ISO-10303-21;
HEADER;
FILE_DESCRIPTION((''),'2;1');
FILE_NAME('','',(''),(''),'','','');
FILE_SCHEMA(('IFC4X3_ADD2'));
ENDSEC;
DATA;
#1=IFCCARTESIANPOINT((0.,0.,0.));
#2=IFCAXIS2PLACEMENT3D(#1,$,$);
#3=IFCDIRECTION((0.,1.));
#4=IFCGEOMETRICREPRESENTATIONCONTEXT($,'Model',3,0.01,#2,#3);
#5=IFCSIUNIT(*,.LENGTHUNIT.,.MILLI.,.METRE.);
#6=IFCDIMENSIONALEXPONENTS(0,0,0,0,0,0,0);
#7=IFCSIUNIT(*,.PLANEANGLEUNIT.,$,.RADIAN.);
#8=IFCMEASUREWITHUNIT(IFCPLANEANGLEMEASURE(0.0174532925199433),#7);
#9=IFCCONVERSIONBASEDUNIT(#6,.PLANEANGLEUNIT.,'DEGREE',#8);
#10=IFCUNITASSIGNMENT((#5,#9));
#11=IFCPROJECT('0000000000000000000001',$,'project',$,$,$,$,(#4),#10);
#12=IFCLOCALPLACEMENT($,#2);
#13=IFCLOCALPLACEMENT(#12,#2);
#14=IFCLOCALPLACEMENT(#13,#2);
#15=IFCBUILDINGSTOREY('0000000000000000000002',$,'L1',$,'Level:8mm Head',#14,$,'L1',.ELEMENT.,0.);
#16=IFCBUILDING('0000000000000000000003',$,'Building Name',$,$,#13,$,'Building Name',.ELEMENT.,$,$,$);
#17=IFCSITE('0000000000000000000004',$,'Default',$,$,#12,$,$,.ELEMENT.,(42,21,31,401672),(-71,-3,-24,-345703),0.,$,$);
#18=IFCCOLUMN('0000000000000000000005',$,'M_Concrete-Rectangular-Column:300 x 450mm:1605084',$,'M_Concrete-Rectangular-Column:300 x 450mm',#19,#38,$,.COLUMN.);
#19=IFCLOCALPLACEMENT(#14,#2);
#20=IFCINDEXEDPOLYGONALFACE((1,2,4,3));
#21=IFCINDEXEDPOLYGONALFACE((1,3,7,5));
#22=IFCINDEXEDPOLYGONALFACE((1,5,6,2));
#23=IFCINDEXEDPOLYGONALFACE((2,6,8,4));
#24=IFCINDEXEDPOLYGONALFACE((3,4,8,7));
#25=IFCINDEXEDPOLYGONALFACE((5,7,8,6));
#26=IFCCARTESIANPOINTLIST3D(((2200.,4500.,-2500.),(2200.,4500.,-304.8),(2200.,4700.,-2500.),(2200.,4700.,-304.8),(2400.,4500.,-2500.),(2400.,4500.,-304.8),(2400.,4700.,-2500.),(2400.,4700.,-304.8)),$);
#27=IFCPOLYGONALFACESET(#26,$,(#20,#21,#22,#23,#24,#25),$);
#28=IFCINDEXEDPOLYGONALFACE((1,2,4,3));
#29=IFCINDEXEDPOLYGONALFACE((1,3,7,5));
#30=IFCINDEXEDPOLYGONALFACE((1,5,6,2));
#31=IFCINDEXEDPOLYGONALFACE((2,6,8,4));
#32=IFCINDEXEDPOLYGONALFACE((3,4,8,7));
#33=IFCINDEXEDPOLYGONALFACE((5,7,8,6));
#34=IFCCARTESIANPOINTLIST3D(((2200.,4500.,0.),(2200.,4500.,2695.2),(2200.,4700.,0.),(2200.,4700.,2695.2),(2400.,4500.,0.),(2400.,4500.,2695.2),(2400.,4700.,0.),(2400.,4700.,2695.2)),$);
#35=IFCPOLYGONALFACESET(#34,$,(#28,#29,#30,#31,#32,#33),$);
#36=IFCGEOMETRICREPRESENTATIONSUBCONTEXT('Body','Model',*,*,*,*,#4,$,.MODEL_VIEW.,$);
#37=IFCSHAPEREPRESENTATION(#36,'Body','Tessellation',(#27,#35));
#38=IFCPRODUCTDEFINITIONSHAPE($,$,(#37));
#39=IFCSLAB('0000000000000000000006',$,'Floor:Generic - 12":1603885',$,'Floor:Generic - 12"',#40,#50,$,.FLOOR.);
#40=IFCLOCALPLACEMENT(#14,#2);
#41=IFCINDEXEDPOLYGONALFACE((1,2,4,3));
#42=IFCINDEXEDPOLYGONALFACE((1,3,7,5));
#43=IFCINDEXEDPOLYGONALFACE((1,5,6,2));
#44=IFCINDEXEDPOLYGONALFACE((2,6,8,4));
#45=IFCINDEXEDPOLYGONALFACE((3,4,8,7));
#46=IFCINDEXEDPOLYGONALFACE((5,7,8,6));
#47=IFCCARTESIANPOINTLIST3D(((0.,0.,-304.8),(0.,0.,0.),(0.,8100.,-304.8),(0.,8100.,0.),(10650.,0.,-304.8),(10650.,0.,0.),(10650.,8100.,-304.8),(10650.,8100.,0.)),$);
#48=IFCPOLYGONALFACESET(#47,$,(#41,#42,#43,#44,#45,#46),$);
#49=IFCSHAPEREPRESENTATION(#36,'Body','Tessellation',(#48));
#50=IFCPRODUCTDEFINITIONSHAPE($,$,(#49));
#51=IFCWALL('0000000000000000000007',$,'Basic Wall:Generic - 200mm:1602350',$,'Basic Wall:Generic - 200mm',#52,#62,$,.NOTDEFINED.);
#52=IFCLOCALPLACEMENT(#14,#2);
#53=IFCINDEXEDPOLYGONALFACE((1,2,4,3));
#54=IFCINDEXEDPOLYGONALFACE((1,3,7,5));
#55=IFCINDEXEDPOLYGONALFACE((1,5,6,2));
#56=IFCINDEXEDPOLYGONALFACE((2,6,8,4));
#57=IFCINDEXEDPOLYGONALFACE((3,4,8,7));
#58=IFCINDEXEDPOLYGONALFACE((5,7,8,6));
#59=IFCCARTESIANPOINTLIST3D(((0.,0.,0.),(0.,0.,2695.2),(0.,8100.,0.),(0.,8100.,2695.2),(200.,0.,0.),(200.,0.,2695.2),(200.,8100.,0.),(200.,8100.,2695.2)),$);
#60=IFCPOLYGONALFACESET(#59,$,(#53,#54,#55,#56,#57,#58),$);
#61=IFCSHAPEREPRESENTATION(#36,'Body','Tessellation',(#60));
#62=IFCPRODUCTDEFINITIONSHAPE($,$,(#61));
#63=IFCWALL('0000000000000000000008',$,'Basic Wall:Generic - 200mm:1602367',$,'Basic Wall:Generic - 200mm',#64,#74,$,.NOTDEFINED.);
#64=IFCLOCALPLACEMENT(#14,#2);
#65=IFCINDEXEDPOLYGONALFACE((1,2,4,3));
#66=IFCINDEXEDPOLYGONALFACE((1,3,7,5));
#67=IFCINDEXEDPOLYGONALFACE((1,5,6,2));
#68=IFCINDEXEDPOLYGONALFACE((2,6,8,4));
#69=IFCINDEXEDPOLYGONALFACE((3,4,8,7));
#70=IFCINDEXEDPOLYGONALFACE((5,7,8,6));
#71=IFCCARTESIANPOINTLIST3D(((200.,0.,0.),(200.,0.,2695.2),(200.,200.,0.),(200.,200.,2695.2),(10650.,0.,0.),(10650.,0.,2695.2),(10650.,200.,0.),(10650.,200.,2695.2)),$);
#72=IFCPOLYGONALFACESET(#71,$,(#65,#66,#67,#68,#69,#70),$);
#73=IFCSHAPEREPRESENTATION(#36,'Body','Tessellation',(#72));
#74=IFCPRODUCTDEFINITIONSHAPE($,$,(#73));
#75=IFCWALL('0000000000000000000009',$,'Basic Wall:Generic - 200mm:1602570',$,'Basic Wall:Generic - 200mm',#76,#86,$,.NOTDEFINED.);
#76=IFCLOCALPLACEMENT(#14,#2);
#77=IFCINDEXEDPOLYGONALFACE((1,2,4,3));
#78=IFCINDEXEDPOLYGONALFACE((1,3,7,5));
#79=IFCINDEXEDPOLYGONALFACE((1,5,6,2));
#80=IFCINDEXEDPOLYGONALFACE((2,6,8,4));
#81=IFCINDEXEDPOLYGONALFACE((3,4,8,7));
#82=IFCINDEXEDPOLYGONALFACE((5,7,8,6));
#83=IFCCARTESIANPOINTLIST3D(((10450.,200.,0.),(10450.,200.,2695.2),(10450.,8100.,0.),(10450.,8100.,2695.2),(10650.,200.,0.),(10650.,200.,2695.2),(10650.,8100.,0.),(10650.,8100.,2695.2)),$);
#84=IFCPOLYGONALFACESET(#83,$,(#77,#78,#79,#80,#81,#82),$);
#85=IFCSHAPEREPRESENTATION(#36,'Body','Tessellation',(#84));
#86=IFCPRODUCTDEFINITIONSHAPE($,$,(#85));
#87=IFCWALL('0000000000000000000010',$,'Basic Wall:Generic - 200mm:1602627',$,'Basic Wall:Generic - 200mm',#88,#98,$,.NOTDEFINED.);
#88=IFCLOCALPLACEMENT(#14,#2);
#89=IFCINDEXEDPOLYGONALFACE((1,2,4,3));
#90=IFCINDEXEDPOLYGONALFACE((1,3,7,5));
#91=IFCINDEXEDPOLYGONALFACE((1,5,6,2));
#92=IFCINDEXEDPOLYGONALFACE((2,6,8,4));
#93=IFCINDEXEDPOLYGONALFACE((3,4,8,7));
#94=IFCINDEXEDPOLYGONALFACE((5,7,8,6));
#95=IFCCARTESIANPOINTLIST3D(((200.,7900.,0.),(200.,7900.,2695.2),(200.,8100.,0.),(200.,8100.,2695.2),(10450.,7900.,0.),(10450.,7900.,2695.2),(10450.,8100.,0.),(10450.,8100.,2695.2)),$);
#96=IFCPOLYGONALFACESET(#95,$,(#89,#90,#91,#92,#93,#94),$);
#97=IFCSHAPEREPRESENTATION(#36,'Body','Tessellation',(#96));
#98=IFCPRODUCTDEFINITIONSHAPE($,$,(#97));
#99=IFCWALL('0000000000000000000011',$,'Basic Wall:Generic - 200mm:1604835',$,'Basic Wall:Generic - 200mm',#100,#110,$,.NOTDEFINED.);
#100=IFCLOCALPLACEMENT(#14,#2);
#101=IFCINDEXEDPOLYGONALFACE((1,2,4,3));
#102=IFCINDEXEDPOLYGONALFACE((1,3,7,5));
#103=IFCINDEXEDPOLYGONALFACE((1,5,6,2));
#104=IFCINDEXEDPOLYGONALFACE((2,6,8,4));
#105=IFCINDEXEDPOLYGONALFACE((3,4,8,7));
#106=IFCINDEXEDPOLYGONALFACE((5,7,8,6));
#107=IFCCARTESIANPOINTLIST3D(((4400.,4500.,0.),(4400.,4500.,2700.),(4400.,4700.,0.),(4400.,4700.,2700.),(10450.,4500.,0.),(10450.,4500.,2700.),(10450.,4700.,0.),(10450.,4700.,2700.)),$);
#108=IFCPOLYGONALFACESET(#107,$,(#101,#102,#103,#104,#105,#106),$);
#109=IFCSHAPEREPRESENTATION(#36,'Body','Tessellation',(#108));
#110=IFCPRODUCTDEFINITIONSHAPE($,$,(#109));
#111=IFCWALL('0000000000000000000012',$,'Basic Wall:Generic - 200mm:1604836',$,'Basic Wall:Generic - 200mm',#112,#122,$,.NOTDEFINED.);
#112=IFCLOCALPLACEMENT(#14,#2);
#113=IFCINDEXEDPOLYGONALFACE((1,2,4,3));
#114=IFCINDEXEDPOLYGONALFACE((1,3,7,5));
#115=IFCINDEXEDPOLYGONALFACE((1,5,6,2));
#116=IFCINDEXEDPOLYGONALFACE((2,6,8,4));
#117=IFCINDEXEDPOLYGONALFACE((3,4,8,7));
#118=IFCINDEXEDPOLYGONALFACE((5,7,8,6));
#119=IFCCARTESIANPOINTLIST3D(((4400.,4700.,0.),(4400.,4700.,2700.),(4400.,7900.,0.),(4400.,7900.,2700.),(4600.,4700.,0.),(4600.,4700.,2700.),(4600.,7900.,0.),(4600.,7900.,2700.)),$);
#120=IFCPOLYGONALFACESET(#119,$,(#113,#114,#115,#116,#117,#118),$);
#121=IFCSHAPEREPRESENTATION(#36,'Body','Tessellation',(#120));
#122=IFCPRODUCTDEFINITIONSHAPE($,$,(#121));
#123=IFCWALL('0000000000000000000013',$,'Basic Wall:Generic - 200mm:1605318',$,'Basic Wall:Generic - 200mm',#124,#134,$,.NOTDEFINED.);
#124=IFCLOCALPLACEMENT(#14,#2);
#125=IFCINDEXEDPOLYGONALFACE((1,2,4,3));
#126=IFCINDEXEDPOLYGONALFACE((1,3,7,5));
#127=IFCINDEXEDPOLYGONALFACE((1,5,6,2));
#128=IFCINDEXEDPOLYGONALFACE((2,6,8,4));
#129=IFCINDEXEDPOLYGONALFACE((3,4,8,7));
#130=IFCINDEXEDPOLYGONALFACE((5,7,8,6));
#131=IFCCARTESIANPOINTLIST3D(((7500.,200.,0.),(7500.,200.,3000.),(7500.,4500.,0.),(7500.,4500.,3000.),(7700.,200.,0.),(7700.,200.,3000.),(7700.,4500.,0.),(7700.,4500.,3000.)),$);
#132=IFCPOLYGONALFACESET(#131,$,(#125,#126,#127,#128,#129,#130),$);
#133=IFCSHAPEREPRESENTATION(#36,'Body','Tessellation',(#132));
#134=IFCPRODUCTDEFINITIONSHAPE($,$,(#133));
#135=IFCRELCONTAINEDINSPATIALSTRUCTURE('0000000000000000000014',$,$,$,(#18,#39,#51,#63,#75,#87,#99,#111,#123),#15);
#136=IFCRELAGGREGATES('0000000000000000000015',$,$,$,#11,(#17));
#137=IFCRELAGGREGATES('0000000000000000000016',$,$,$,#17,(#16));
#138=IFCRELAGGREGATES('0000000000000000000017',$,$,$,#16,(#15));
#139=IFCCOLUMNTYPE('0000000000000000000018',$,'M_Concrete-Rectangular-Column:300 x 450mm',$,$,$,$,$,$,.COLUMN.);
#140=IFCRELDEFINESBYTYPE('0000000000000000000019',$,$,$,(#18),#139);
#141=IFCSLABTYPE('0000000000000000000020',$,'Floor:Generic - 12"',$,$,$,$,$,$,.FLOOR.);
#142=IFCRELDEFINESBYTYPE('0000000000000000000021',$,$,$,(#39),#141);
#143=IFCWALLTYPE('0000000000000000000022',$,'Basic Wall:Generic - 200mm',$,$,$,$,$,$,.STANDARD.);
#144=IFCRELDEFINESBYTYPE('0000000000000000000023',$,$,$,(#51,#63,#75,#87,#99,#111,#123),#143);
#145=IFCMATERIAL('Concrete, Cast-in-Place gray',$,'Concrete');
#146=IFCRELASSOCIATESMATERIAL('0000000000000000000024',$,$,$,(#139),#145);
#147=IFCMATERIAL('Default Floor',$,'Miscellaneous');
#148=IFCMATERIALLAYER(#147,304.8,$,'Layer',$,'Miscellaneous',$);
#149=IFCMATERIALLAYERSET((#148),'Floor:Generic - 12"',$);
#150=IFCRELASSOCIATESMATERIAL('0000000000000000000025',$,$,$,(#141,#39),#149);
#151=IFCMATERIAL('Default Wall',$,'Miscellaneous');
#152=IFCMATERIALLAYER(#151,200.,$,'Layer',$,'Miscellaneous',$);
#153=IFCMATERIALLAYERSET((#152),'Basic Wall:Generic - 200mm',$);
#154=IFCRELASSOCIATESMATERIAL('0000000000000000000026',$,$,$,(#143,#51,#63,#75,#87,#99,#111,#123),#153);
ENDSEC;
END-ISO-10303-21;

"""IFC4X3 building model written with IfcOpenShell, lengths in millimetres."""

from ifc_helpers import new_model, entity, si_unit, converted_unit, direction, frame, frame_2d, origin, place, context, subcontext, project, spatial, polyline, rectangle, extrude, clip, bounded_halfspace, source, transform, mapped, material, layer, layer_set, layer_usage, material_profile, profile_set, type_object, type_shapes, element, save


model = new_model("IFC4X3")

# Units and contexts
model_context = context("Model", 3, precision=0.01, world=origin(), true_north=direction((0.0, 1.0)))
body_context = subcontext(model_context, "Body", "Model", "MODEL_VIEW")
ifc_project = project(units=[si_unit("LENGTHUNIT", "METRE", prefix="MILLI"), converted_unit("PLANEANGLEUNIT", "DEGREE", entity("IfcPlaneAngleMeasure", 0.0174532925199433), si_unit("PLANEANGLEUNIT", "RADIAN"), dimensions=[0, 0, 0, 0, 0, 0, 0])], contexts=[model_context])

# Site, building, storey
site_placement = place(None, origin())
site = spatial("IfcSite", under=ifc_project, at=site_placement, Name="Default", CompositionType="ELEMENT", RefLatitude=(42, 21, 31, 401672), RefLongitude=(-71, -3, -24, -345703), RefElevation=0.0)
building_placement = place(site_placement, origin())
building = spatial("IfcBuilding", under=site, at=building_placement, Name="Building Name", LongName="Building Name", CompositionType="ELEMENT")
storey_placement = place(building_placement, origin())
storey = spatial("IfcBuildingStorey", under=building, at=storey_placement, Name="L1", ObjectType="Level:8mm Head", LongName="L1", CompositionType="ELEMENT", Elevation=0.0)

# Column
ifc_material_1 = material(Name="Concrete, Cast-in-Place gray", Category="Concrete")
ifc_material_profile_1 = material_profile(ifc_material_1, rectangle(XDim=200.0, YDim=200.0, at=frame_2d((0.0, 0.0), x_axis=(1.0, 0.0))), Name="300 x 450mm")
ifc_material_profile_2 = material_profile(ifc_material_1, rectangle(XDim=200.0, YDim=200.0, at=frame_2d((0.0, 0.0), x_axis=(1.0, 0.0))), Name="300 x 450mm")
ifc_profile_set = profile_set([ifc_material_profile_1, ifc_material_profile_2], Name="300 x 450mm")
column_type = type_object("IfcColumnType", Name="M_Concrete-Rectangular-Column:300 x 450mm", PredefinedType="COLUMN", material=ifc_profile_set)
shared_shape = source(origin(), body_context, "Body", "SweptSolid", [
    extrude(rectangle(XDim=200.0, YDim=200.0, at=frame_2d((0.0, 0.0), x_axis=(1.0, 0.0))), frame((2300.0, 4600.0, -2500.0), z_axis=(0.0, 0.0, 1.0), x_axis=(-1.0, 0.0, 0.0)), (0.0, 0.0, 1.0), 2195.2),
    extrude(rectangle(XDim=200.0, YDim=200.0, at=frame_2d((0.0, 0.0), x_axis=(1.0, 0.0))), frame((2300.0, 4600.0, 0.0), z_axis=(0.0, 0.0, 1.0), x_axis=(-1.0, 0.0, 0.0)), (0.0, 0.0, 1.0), 2695.2),
])
type_shapes(column_type, [shared_shape])
column_placement = place(storey_placement, origin())
element("IfcColumn", 1, at=column_placement, inside=storey, type_object=column_type, Name="M_Concrete-Rectangular-Column:300 x 450mm:1605084", ObjectType="M_Concrete-Rectangular-Column:300 x 450mm", PredefinedType="COLUMN", context=body_context, shape_type="MappedRepresentation", body=[
    mapped(shared_shape, transform((0.0, 0.0, 0.0), scale=1.0)),
])

# Slab
ifc_material_2 = material(Name="Default Floor", Category="Miscellaneous")
ifc_layer_1 = layer(ifc_material_2, 304.8, Name="Layer", Category="Miscellaneous")
ifc_layer_set_1 = layer_set([ifc_layer_1], Name="Floor:Generic - 12\"")
ifc_layer_usage = layer_usage(ifc_layer_set_1, "AXIS3", "POSITIVE", 0.0)
slab_type = type_object("IfcSlabType", Name="Floor:Generic - 12\"", PredefinedType="FLOOR", material=ifc_layer_set_1)
slab_placement = place(storey_placement, origin())
element("IfcSlab", 2, at=slab_placement, inside=storey, type_object=slab_type, material=ifc_layer_usage, Name="Floor:Generic - 12\":1603885", ObjectType="Floor:Generic - 12\"", PredefinedType="FLOOR", context=body_context, shape_type="SweptSolid", body=[
    extrude(rectangle(XDim=8100.0, YDim=10650.0, at=frame_2d((0.0, 0.0), x_axis=(1.0, 0.0))), frame((5325.0, 4050.0, 0.0), z_axis=(0.0, 0.0, -1.0), x_axis=(0.0, 1.0, 0.0)), (0.0, 0.0, 1.0), 304.8),
])

# Walls
ifc_material_3 = material(Name="Default Wall", Category="Miscellaneous")
ifc_layer_2 = layer(ifc_material_3, 200.0, Name="Layer", Category="Miscellaneous")
ifc_layer_set_2 = layer_set([ifc_layer_2], Name="Basic Wall:Generic - 200mm")
wall_type = type_object("IfcWallType", Name="Basic Wall:Generic - 200mm", PredefinedType="STANDARD", material=ifc_layer_set_2)
wall_1_placement = place(storey_placement, frame((100.0, 8100.0, 0.0), z_axis=(0.0, 0.0, 1.0), x_axis=(0.0, -1.0, 0.0)))
element("IfcWall", 3, at=wall_1_placement, inside=storey, type_object=wall_type, material=ifc_layer_set_2, Name="Basic Wall:Generic - 200mm:1602350", ObjectType="Basic Wall:Generic - 200mm", PredefinedType="NOTDEFINED", context=body_context, shape_type="Clipping", body=[
    clip(extrude(rectangle(XDim=8100.0, YDim=200.0, at=frame_2d((4050.0, 0.0), x_axis=(-1.0, 0.0))), origin(), (0.0, 0.0, 1.0), 2695.2), bounded_halfspace(frame((0.0, -100.0, 2695.2), z_axis=(0.0, 0.0, -1.0), x_axis=(0.0, 1.0, 0.0)), True, frame((0.0, -100.0, 2695.2)), polyline([(0.0, 0.0), (8100.0, 0.0), (8100.0, 200.0), (7900.0, 200.0), (200.0, 200.0), (0.0, 200.0), (0.0, 0.0)]))),
])
wall_2_placement = place(storey_placement, frame((200.0, 100.0, 0.0)))
element("IfcWall", 4, at=wall_2_placement, inside=storey, type_object=wall_type, material=ifc_layer_set_2, Name="Basic Wall:Generic - 200mm:1602367", ObjectType="Basic Wall:Generic - 200mm", PredefinedType="NOTDEFINED", context=body_context, shape_type="Clipping", body=[
    clip(extrude(rectangle(XDim=10450.0, YDim=200.0, at=frame_2d((5225.0, 0.0), x_axis=(-1.0, 0.0))), origin(), (0.0, 0.0, 1.0), 2695.2), bounded_halfspace(frame((0.0, -100.0, 2695.2), z_axis=(0.0, 0.0, -1.0), x_axis=(1.0, 0.0, 0.0)), True, frame((0.0, -100.0, 2695.2)), polyline([(0.0, 0.0), (10450.0, 0.0), (10450.0, 200.0), (10250.0, 200.0), (0.0, 200.0), (0.0, 0.0)]))),
])
wall_3_placement = place(storey_placement, frame((10550.0, 200.0, 0.0), z_axis=(0.0, 0.0, 1.0), x_axis=(0.0, 1.0, 0.0)))
element("IfcWall", 5, at=wall_3_placement, inside=storey, type_object=wall_type, material=ifc_layer_set_2, Name="Basic Wall:Generic - 200mm:1602570", ObjectType="Basic Wall:Generic - 200mm", PredefinedType="NOTDEFINED", context=body_context, shape_type="Clipping", body=[
    clip(extrude(rectangle(XDim=7900.0, YDim=200.0, at=frame_2d((3950.0, 0.0), x_axis=(-1.0, 0.0))), origin(), (0.0, 0.0, 1.0), 2695.2), bounded_halfspace(frame((0.0, -100.0, 2695.2), z_axis=(0.0, 0.0, -1.0), x_axis=(0.0, -1.0, 0.0)), True, frame((0.0, -100.0, 2695.2)), polyline([(0.0, 0.0), (7900.0, 0.0), (7900.0, 200.0), (7700.0, 200.0), (0.0, 200.0), (0.0, 0.0)]))),
])
wall_4_placement = place(storey_placement, frame((10450.0, 8000.0, 0.0), z_axis=(0.0, 0.0, 1.0), x_axis=(-1.0, 0.0, 0.0)))
element("IfcWall", 6, at=wall_4_placement, inside=storey, type_object=wall_type, material=ifc_layer_set_2, Name="Basic Wall:Generic - 200mm:1602627", ObjectType="Basic Wall:Generic - 200mm", PredefinedType="NOTDEFINED", context=body_context, shape_type="Clipping", body=[
    clip(extrude(rectangle(XDim=10250.0, YDim=200.0, at=frame_2d((5125.0, 0.0), x_axis=(-1.0, 0.0))), origin(), (0.0, 0.0, 1.0), 2695.2), bounded_halfspace(frame((0.0, -100.0, 2695.2), z_axis=(0.0, 0.0, -1.0), x_axis=(-1.0, 0.0, 0.0)), True, frame((0.0, -100.0, 2695.2)), polyline([(0.0, 0.0), (10250.0, 0.0), (10250.0, 200.0), (0.0, 200.0), (0.0, 0.0)]))),
])
wall_5_placement = place(storey_placement, frame((10450.0, 4600.0, 0.0), z_axis=(0.0, 0.0, 1.0), x_axis=(-1.0, 0.0, 0.0)))
element("IfcWall", 7, at=wall_5_placement, inside=storey, type_object=wall_type, material=ifc_layer_set_2, Name="Basic Wall:Generic - 200mm:1604835", ObjectType="Basic Wall:Generic - 200mm", PredefinedType="NOTDEFINED", context=body_context, shape_type="SweptSolid", body=[
    extrude(rectangle(XDim=6050.0, YDim=200.0, at=frame_2d((3025.0, 0.0), x_axis=(-1.0, 0.0))), origin(), (0.0, 0.0, 1.0), 2700.0),
])
wall_6_placement = place(storey_placement, frame((4500.0, 4700.0, 0.0), z_axis=(0.0, 0.0, 1.0), x_axis=(0.0, 1.0, 0.0)))
element("IfcWall", 8, at=wall_6_placement, inside=storey, type_object=wall_type, material=ifc_layer_set_2, Name="Basic Wall:Generic - 200mm:1604836", ObjectType="Basic Wall:Generic - 200mm", PredefinedType="NOTDEFINED", context=body_context, shape_type="SweptSolid", body=[
    extrude(rectangle(XDim=3200.0, YDim=200.0, at=frame_2d((1600.0, 0.0), x_axis=(-1.0, 0.0))), origin(), (0.0, 0.0, 1.0), 2700.0),
])
wall_7_placement = place(storey_placement, frame((7600.0, 4500.0, 0.0), z_axis=(0.0, 0.0, 1.0), x_axis=(0.0, -1.0, 0.0)))
element("IfcWall", 9, at=wall_7_placement, inside=storey, type_object=wall_type, material=ifc_layer_set_2, Name="Basic Wall:Generic - 200mm:1605318", ObjectType="Basic Wall:Generic - 200mm", PredefinedType="NOTDEFINED", context=body_context, shape_type="SweptSolid", body=[
    extrude(rectangle(XDim=4300.0, YDim=200.0, at=frame_2d((2150.0, 0.0), x_axis=(-1.0, 0.0))), origin(), (0.0, 0.0, 1.0), 3000.0),
])

save(model, "model.ifc")
